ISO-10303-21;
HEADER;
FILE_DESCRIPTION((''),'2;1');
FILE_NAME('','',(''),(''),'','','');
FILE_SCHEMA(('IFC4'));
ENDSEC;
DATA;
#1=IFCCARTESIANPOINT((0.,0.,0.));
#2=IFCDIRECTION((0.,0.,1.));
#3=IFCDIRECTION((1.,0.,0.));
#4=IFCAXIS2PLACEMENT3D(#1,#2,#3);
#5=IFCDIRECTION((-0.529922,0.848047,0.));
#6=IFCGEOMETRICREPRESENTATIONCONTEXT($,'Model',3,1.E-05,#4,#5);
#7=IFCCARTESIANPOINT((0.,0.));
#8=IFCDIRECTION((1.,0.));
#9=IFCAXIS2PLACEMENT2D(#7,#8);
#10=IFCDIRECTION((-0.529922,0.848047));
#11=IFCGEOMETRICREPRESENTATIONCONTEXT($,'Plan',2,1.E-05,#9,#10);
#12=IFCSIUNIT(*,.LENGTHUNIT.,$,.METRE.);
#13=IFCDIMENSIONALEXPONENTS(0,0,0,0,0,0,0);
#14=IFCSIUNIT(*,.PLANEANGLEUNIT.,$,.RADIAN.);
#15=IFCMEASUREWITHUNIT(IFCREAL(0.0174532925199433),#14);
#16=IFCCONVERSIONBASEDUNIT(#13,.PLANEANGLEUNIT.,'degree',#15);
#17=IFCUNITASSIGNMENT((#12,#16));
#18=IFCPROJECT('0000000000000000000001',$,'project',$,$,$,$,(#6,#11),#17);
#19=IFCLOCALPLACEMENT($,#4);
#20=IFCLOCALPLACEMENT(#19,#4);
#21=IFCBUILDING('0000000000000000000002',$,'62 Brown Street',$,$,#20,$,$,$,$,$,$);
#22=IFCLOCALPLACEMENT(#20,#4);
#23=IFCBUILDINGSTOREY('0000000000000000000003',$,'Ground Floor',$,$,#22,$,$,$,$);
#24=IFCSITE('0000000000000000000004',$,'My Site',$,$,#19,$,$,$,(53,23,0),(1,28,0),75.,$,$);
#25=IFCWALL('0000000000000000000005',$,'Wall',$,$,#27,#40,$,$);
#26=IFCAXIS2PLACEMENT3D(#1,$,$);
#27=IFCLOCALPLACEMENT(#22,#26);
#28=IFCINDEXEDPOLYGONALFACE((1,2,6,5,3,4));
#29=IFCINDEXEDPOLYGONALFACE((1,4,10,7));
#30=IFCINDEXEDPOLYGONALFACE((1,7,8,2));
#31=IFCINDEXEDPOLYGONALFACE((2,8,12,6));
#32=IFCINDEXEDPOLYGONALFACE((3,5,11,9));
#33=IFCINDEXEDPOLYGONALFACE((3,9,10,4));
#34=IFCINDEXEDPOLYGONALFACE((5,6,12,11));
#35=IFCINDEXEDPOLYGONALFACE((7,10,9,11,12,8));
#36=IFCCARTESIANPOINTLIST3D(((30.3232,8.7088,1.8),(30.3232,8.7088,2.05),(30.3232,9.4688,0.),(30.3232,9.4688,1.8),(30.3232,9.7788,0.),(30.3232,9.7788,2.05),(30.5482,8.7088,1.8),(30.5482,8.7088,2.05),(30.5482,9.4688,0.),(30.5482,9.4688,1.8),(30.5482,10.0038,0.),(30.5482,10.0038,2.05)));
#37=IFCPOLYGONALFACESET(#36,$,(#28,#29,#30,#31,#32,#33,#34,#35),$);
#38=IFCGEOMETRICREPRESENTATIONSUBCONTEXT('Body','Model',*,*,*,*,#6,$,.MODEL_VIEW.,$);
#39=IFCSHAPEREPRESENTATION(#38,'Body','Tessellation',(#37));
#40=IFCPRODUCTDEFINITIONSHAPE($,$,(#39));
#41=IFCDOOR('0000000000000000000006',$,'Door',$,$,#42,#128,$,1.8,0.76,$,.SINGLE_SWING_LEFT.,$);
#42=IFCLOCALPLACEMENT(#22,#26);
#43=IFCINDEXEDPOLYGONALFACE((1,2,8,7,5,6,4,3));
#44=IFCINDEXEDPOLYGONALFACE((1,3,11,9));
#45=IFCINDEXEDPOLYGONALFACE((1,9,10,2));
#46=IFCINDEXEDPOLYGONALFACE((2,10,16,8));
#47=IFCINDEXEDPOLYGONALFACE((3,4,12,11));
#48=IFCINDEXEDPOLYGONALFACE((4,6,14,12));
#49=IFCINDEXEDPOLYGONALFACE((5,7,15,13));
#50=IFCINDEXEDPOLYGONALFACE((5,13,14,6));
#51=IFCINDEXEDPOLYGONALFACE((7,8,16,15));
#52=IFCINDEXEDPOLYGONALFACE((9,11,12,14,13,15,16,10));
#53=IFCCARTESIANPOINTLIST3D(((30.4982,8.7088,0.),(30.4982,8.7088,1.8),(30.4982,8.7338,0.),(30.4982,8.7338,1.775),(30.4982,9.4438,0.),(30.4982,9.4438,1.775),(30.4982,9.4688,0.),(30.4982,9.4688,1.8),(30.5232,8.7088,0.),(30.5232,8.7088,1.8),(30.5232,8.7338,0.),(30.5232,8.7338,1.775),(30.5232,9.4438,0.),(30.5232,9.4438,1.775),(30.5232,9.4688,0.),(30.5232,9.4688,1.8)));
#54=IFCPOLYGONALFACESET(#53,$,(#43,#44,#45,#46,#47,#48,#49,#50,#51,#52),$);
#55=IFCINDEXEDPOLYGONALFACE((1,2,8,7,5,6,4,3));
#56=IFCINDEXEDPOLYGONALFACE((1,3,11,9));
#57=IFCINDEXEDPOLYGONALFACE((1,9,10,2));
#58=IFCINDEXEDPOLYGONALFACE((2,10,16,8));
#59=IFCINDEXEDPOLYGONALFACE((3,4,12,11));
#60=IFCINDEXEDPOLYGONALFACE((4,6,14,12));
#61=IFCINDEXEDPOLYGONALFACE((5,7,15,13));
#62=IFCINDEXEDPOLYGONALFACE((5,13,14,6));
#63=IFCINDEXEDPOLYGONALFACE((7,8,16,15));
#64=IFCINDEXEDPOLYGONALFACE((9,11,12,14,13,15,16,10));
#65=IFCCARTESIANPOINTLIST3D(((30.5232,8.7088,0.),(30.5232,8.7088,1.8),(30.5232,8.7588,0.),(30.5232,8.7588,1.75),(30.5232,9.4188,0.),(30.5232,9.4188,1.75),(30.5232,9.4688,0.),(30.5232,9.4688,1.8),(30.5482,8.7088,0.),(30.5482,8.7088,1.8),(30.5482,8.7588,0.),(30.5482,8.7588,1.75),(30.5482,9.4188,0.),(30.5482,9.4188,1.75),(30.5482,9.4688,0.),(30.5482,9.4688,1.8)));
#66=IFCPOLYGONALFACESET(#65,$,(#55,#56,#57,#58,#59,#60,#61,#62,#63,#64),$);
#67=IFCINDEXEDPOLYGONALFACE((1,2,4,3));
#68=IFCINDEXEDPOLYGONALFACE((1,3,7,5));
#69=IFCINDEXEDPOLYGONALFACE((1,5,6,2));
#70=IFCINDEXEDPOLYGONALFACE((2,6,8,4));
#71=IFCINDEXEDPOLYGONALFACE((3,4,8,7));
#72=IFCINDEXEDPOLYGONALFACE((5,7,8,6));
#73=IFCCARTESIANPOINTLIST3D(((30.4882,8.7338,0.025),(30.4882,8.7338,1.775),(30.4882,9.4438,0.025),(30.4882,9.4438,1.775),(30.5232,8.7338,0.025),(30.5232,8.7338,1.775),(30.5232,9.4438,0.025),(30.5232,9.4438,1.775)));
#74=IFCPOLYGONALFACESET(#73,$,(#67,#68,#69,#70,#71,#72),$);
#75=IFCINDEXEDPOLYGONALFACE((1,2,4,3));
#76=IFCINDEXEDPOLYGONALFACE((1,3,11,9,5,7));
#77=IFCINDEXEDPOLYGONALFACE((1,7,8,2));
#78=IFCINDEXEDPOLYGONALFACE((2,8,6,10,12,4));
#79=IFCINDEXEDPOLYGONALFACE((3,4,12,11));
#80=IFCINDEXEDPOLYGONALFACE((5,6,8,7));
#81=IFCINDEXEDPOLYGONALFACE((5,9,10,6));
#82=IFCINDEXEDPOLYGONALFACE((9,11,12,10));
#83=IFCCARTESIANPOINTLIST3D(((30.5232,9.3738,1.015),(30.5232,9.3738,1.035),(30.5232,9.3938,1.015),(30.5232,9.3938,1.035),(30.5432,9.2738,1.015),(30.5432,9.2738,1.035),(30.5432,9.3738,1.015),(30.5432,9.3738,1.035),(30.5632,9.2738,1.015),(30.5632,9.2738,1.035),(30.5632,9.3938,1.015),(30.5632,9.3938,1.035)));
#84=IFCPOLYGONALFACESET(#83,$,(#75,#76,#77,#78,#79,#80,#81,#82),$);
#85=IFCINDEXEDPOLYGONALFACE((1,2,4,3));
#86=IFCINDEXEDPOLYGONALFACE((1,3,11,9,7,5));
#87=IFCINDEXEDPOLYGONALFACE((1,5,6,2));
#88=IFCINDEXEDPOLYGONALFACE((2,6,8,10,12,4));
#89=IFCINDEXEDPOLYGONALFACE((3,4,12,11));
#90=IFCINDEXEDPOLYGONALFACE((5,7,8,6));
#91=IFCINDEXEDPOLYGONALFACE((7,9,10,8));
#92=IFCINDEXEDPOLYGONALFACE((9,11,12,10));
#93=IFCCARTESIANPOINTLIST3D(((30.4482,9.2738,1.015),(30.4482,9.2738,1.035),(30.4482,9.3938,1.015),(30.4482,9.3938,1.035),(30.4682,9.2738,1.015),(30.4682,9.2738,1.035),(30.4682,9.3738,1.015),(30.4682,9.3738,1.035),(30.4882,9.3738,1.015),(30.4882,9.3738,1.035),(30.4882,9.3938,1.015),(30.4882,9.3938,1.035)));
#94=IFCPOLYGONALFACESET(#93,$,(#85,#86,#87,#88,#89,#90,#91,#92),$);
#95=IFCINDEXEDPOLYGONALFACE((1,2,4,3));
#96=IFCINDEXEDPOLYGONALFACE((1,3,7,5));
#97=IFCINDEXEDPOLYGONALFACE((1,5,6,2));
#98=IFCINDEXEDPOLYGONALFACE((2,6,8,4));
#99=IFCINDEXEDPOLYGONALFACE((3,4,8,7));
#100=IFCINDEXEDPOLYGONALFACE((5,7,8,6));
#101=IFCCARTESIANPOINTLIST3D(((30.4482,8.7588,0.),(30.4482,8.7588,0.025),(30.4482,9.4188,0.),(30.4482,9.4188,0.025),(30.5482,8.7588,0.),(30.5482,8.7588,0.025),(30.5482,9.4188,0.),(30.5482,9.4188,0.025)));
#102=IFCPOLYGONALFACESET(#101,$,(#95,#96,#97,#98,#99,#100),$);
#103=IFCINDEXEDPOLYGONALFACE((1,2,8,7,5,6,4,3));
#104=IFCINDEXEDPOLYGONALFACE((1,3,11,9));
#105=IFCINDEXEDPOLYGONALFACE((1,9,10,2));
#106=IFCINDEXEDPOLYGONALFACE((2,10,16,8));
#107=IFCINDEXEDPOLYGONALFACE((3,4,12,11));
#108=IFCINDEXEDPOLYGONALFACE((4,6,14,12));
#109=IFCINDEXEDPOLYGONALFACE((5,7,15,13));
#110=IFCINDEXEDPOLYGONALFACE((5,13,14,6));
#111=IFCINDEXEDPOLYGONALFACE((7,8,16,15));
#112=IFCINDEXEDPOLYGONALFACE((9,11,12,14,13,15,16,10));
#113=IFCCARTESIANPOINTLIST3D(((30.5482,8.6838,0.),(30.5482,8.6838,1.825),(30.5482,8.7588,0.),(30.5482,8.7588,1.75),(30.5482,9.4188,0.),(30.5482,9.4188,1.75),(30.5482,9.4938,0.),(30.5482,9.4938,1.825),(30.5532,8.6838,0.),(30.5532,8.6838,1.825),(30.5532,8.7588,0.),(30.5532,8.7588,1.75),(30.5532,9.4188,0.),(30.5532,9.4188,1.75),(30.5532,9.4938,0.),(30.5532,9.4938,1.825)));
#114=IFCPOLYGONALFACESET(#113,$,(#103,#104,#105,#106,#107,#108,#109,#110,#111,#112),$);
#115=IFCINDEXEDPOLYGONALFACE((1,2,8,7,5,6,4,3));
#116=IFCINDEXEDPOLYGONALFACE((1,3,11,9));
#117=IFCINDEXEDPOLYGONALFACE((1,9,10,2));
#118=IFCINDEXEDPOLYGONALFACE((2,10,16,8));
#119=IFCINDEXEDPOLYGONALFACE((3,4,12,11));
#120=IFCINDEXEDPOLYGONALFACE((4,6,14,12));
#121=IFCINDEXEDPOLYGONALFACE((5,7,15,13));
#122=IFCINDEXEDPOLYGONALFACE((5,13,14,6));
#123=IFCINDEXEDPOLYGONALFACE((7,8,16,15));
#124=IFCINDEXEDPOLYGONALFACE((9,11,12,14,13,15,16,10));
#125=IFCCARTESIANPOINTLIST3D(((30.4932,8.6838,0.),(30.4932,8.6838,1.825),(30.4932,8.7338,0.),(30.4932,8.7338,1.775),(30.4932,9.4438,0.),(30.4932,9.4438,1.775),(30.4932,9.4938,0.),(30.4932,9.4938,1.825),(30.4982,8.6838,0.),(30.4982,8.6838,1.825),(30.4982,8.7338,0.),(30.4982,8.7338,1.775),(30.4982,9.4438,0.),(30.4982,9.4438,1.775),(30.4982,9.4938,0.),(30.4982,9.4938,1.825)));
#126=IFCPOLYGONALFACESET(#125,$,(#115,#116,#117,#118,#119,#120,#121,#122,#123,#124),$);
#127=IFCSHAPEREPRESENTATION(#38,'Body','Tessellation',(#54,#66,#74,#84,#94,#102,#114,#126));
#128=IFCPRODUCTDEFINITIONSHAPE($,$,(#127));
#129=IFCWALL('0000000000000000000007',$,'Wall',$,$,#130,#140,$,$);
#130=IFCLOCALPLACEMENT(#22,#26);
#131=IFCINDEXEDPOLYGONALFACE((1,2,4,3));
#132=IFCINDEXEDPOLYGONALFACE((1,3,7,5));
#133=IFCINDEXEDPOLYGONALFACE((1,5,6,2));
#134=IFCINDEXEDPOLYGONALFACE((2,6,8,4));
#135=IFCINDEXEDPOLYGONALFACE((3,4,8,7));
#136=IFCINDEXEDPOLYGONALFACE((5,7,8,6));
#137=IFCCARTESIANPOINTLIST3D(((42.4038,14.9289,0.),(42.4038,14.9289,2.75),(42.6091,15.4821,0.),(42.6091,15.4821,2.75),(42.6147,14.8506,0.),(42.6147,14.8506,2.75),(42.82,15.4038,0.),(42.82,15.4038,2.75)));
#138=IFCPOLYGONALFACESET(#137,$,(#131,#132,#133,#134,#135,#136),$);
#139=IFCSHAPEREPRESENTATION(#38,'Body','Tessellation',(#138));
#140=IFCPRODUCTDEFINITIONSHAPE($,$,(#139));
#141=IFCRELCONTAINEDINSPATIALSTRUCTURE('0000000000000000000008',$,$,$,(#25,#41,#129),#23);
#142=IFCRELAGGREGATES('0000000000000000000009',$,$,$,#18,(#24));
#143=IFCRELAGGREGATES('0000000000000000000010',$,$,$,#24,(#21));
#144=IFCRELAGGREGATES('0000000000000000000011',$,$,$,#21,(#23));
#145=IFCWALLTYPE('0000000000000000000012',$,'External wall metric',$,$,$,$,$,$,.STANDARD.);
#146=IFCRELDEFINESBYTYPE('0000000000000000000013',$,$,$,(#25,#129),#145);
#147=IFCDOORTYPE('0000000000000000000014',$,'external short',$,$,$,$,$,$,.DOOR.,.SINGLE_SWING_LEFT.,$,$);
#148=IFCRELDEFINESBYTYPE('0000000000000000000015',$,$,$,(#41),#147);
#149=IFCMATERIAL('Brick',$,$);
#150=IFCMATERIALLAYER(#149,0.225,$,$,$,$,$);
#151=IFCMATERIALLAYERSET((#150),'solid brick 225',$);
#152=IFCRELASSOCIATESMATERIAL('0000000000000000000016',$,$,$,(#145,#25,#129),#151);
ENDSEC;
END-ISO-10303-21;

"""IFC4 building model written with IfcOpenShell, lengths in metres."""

from ifc_helpers import new_model, entity, si_unit, converted_unit, direction, frame, origin_with_axes, origin_2d_with_axis, place, context, subcontext, project, spatial, line, indexed_curve, outline, extrude, clip, halfspace, shape, source, transform, mapped, material, layer, layer_set, layer_usage, type_object, type_shapes, element, fill, save


model = new_model("IFC4")

# Units and contexts
model_context = context("Model", 3, precision=1e-05, world=origin_with_axes(), true_north=direction((-0.529922, 0.848047, 0.0)))
plan_context = context("Plan", 2, precision=1e-05, world=origin_2d_with_axis(), true_north=direction((-0.529922, 0.848047)))
body_context_1 = subcontext(model_context, "Body", "Model", "MODEL_VIEW")
body_context_2 = subcontext(plan_context, "Body", "Plan", "PLAN_VIEW")
ifc_project = project(units=[si_unit("LENGTHUNIT", "METRE"), converted_unit("PLANEANGLEUNIT", "degree", entity("IfcReal", 0.0174532925199433), si_unit("PLANEANGLEUNIT", "RADIAN"), dimensions=[0, 0, 0, 0, 0, 0, 0])], contexts=[model_context, plan_context])

# Site, building, storey
site_placement = place(None, origin_with_axes())
site = spatial("IfcSite", under=ifc_project, at=site_placement, Name="My Site", RefLatitude=(53, 23, 0), RefLongitude=(1, 28, 0), RefElevation=75.0)
building_placement = place(site_placement, origin_with_axes())
building = spatial("IfcBuilding", under=site, at=building_placement, Name="62 Brown Street")
storey_placement = place(building_placement, origin_with_axes())
storey = spatial("IfcBuildingStorey", under=building, at=storey_placement, Name="Ground Floor")

# Shared definitions
ifc_material_1 = material(Name="Brick")
ifc_layer_1 = layer(ifc_material_1, 0.225)
ifc_layer_set_1 = layer_set([ifc_layer_1], Name="solid brick 225")
wall_type_1 = type_object("IfcWallType", Name="External wall metric", PredefinedType="STANDARD", material=ifc_layer_set_1)

# Wall, opening, door
ifc_layer_usage_1 = layer_usage(ifc_layer_set_1, "AXIS2", "POSITIVE", 0.0)
wall_1_placement = place(storey_placement, frame((30.5482, 8.7088, 0.0), z_axis=(0.0, 0.0, 1.0), x_axis=(0.0, 1.0, 0.0)))
wall_1 = element("IfcWall", 1, at=wall_1_placement, inside=storey, type_object=wall_type_1, material=ifc_layer_usage_1, Name="Wall", context=body_context_1, shape_type="Clipping", body=[
    clip(extrude(outline(indexed_curve([(0.0, 0.0), (0.0, 0.225), (1.295, 0.225), (1.295, 0.0), (0.0, 0.0)], self_intersect=False)), origin_with_axes(), (0.0, 0.0, 1.0), 2.05), halfspace(frame((1.295, 0.0, 0.0), z_axis=(0.450001, 0.450001, 0.0), x_axis=(-0.225, 0.225, 0.0)), False)),
])
shared_shape_1 = source(origin_with_axes(), body_context_1, "Body", "SweptSolid", [
    extrude(outline(indexed_curve([(0.0, 0.0), (0.76, 0.0), (0.76, 1.8), (0.0, 1.8)], segments=[line(1, 2, 3, 4, 1)])), frame((0.0, -0.1, 0.0), z_axis=(0.0, -1.0, 0.0), x_axis=(1.0, 0.0, 0.0)), (0.0, 0.0, -1.0), 0.425),
])
opening_1_placement = place(wall_1_placement, frame((0.0, 0.0, 0.0), z_axis=(0.0, 0.0, 1.0), x_axis=(1.0, 0.0, 0.0)))
opening_1 = element("IfcOpeningElement", 2, at=opening_1_placement, cuts=wall_1, PredefinedType="OPENING", context=body_context_1, shape_type="MappedRepresentation", body=[
    mapped(shared_shape_1, transform((0.0, 0.0, 0.0), x_axis=(1.0, 0.0, 0.0), y_axis=(0.0, 1.0, 0.0), z_axis=(0.0, 0.0, 1.0), scale=1.0)),
])
door_type_1 = type_object("IfcDoorType", Name="external short", OperationType="SINGLE_SWING_LEFT", PredefinedType="DOOR")
shared_shape_2 = source(origin_with_axes(), body_context_1, "Body", "SweptSolid", [
    extrude(outline(indexed_curve([(0.0, 0.0), (0.0, 1.8), (0.76, 1.8), (0.76, 0.0), (0.735, 0.0), (0.735, 1.775), (0.025, 1.775), (0.025, 0.0)], segments=[line(1, 2, 3, 4, 5, 6, 7, 8, 1)])), frame((0.0, 0.025, 0.0), z_axis=(0.0, -1.0, 0.0), x_axis=(1.0, 0.0, 0.0)), (0.0, 0.0, -1.0), 0.025),
    extrude(outline(indexed_curve([(0.0, 0.0), (0.0, 1.8), (0.76, 1.8), (0.76, 0.0), (0.71, 0.0), (0.71, 1.75), (0.05, 1.75), (0.05, 0.0)], segments=[line(1, 2, 3, 4, 5, 6, 7, 8, 1)])), frame((0.0, 0.0, 0.0), z_axis=(0.0, -1.0, 0.0), x_axis=(1.0, 0.0, 0.0)), (0.0, 0.0, -1.0), 0.025),
    extrude(outline(indexed_curve([(0.0, 0.0), (0.71, 0.0), (0.71, 0.035), (0.0, 0.035)], segments=[line(1, 2, 3, 4, 1)])), frame((0.025, 0.025, 0.025), z_axis=(0.0, 0.0, 1.0), x_axis=(1.0, 0.0, 0.0)), (0.0, 0.0, 1.0), 1.75),
    extrude(outline(indexed_curve([(0.0, 0.0), (0.0, -0.04), (-0.12, -0.04), (-0.12, -0.02), (-0.02, -0.02), (-0.02, 0.0)], segments=[line(1, 2, 3, 4, 5, 6, 1)])), frame((0.685, 0.025, 1.015), z_axis=(0.0, 0.0, 1.0), x_axis=(1.0, 0.0, 0.0)), (0.0, 0.0, 1.0), 0.02),
    extrude(outline(indexed_curve([(0.0, 0.0), (0.0, 0.04), (-0.12, 0.04), (-0.12, 0.02), (-0.02, 0.02), (-0.02, 0.0)], segments=[line(1, 2, 3, 4, 5, 6, 1)])), frame((0.685, 0.06, 1.015), z_axis=(0.0, 0.0, 1.0), x_axis=(1.0, 0.0, 0.0)), (0.0, 0.0, 1.0), 0.02),
    extrude(outline(indexed_curve([(0.0, 0.0), (0.66, 0.0), (0.66, 0.1), (0.0, 0.1)], segments=[line(1, 2, 3, 4, 1)])), frame((0.05, 0.0, 0.0), z_axis=(0.0, 0.0, 1.0), x_axis=(1.0, 0.0, 0.0)), (0.0, 0.0, 1.0), 0.025),
    extrude(outline(indexed_curve([(0.0, 0.0), (0.0, 1.825), (0.81, 1.825), (0.81, 0.0), (0.735, 0.0), (0.735, 1.75), (0.075, 1.75), (0.075, 0.0)], segments=[line(1, 2, 3, 4, 5, 6, 7, 8, 1)])), frame((-0.025, -0.005, 0.0), z_axis=(0.0, -1.0, 0.0), x_axis=(1.0, 0.0, 0.0)), (0.0, 0.0, -1.0), 0.005),
    extrude(outline(indexed_curve([(0.0, 0.0), (0.0, 1.825), (0.81, 1.825), (0.81, 0.0), (0.76, 0.0), (0.76, 1.775), (0.05, 1.775), (0.05, 0.0)], segments=[line(1, 2, 3, 4, 5, 6, 7, 8, 1)])), frame((-0.025, 0.05, 0.0), z_axis=(0.0, -1.0, 0.0), x_axis=(1.0, 0.0, 0.0)), (0.0, 0.0, -1.0), 0.005),
])
shared_shape_3 = source(origin_with_axes(), body_context_2, "Body", "Curve2D", [
    entity("IfcIndexedPolyCurve", entity("IfcCartesianPointList2D", [[0.0, 0.0], [0.0, 0.05], [0.025, 0.05], [0.025, 0.025], [0.05, 0.025], [0.05, 0.0]]), [entity("IfcLineIndex", [1, 2, 3, 4, 5, 6, 1])]),
    entity("IfcIndexedPolyCurve", entity("IfcCartesianPointList2D", [[0.76, 0.0], [0.76, 0.05], [0.735, 0.05], [0.735, 0.025], [0.71, 0.025], [0.71, 0.0]]), [entity("IfcLineIndex", [1, 2, 3, 4, 5, 6, 1])]),
    entity("IfcTrimmedCurve", entity("IfcEllipse", entity("IfcAxis2Placement2D", entity("IfcCartesianPoint", [0.06, 0.05]), entity("IfcDirection", [1.0, 0.0])), 0.675, 0.71), [entity("IfcCartesianPoint", [0.735, 0.05])], [entity("IfcCartesianPoint", [0.06, 0.76])], True, "CARTESIAN"),
    entity("IfcIndexedPolyCurve", entity("IfcCartesianPointList2D", [[0.025, 0.05], [0.06, 0.05], [0.06, 0.76], [0.025, 0.76]]), [entity("IfcLineIndex", [1, 2, 3, 4, 1])]),
])
type_shapes(door_type_1, [shared_shape_2, shared_shape_3])
door_1_placement = place(opening_1_placement, frame((0.0, 0.0, 0.0), z_axis=(0.0, 0.0, 1.0), x_axis=(1.0, 0.0, 0.0)))
door_1 = element("IfcDoor", 3, at=door_1_placement, inside=storey, type_object=door_type_1, Name="Door", OperationType="SINGLE_SWING_LEFT", OverallHeight=1.8, OverallWidth=0.76, shapes=[
    shape(body_context_1, "Body", "MappedRepresentation", [mapped(shared_shape_2, transform((0.0, 0.0, 0.0), x_axis=(1.0, 0.0, 0.0), y_axis=(0.0, 1.0, 0.0), z_axis=(0.0, 0.0, 1.0), scale=1.0))]),
    shape(body_context_2, "Body", "MappedRepresentation", [mapped(shared_shape_3, transform((0.0, 0.0, 0.0), x_axis=(1.0, 0.0, 0.0), y_axis=(0.0, 1.0, 0.0), z_axis=(0.0, 0.0, 1.0), scale=1.0))]),
])
fill(opening_1, door_1)

# Wall
ifc_layer_usage_2 = layer_usage(ifc_layer_set_1, "AXIS2", "POSITIVE", 0.0)
wall_2_placement = place(storey_placement, frame((42.6147, 14.8506, 0.0), z_axis=(0.0, 0.0, 1.0), x_axis=(0.347944, 0.937515, 0.0)))
element("IfcWall", 4, at=wall_2_placement, inside=storey, type_object=wall_type_1, material=ifc_layer_usage_2, Name="Wall", context=body_context_1, shape_type="SweptSolid", body=[
    extrude(outline(indexed_curve([(0.0, 0.0), (0.0, 0.225), (0.5901, 0.225), (0.5901, 0.0), (0.0, 0.0)], self_intersect=False)), origin_with_axes(), (0.0, 0.0, 1.0), 2.75),
])

save(model, "model.ifc")
